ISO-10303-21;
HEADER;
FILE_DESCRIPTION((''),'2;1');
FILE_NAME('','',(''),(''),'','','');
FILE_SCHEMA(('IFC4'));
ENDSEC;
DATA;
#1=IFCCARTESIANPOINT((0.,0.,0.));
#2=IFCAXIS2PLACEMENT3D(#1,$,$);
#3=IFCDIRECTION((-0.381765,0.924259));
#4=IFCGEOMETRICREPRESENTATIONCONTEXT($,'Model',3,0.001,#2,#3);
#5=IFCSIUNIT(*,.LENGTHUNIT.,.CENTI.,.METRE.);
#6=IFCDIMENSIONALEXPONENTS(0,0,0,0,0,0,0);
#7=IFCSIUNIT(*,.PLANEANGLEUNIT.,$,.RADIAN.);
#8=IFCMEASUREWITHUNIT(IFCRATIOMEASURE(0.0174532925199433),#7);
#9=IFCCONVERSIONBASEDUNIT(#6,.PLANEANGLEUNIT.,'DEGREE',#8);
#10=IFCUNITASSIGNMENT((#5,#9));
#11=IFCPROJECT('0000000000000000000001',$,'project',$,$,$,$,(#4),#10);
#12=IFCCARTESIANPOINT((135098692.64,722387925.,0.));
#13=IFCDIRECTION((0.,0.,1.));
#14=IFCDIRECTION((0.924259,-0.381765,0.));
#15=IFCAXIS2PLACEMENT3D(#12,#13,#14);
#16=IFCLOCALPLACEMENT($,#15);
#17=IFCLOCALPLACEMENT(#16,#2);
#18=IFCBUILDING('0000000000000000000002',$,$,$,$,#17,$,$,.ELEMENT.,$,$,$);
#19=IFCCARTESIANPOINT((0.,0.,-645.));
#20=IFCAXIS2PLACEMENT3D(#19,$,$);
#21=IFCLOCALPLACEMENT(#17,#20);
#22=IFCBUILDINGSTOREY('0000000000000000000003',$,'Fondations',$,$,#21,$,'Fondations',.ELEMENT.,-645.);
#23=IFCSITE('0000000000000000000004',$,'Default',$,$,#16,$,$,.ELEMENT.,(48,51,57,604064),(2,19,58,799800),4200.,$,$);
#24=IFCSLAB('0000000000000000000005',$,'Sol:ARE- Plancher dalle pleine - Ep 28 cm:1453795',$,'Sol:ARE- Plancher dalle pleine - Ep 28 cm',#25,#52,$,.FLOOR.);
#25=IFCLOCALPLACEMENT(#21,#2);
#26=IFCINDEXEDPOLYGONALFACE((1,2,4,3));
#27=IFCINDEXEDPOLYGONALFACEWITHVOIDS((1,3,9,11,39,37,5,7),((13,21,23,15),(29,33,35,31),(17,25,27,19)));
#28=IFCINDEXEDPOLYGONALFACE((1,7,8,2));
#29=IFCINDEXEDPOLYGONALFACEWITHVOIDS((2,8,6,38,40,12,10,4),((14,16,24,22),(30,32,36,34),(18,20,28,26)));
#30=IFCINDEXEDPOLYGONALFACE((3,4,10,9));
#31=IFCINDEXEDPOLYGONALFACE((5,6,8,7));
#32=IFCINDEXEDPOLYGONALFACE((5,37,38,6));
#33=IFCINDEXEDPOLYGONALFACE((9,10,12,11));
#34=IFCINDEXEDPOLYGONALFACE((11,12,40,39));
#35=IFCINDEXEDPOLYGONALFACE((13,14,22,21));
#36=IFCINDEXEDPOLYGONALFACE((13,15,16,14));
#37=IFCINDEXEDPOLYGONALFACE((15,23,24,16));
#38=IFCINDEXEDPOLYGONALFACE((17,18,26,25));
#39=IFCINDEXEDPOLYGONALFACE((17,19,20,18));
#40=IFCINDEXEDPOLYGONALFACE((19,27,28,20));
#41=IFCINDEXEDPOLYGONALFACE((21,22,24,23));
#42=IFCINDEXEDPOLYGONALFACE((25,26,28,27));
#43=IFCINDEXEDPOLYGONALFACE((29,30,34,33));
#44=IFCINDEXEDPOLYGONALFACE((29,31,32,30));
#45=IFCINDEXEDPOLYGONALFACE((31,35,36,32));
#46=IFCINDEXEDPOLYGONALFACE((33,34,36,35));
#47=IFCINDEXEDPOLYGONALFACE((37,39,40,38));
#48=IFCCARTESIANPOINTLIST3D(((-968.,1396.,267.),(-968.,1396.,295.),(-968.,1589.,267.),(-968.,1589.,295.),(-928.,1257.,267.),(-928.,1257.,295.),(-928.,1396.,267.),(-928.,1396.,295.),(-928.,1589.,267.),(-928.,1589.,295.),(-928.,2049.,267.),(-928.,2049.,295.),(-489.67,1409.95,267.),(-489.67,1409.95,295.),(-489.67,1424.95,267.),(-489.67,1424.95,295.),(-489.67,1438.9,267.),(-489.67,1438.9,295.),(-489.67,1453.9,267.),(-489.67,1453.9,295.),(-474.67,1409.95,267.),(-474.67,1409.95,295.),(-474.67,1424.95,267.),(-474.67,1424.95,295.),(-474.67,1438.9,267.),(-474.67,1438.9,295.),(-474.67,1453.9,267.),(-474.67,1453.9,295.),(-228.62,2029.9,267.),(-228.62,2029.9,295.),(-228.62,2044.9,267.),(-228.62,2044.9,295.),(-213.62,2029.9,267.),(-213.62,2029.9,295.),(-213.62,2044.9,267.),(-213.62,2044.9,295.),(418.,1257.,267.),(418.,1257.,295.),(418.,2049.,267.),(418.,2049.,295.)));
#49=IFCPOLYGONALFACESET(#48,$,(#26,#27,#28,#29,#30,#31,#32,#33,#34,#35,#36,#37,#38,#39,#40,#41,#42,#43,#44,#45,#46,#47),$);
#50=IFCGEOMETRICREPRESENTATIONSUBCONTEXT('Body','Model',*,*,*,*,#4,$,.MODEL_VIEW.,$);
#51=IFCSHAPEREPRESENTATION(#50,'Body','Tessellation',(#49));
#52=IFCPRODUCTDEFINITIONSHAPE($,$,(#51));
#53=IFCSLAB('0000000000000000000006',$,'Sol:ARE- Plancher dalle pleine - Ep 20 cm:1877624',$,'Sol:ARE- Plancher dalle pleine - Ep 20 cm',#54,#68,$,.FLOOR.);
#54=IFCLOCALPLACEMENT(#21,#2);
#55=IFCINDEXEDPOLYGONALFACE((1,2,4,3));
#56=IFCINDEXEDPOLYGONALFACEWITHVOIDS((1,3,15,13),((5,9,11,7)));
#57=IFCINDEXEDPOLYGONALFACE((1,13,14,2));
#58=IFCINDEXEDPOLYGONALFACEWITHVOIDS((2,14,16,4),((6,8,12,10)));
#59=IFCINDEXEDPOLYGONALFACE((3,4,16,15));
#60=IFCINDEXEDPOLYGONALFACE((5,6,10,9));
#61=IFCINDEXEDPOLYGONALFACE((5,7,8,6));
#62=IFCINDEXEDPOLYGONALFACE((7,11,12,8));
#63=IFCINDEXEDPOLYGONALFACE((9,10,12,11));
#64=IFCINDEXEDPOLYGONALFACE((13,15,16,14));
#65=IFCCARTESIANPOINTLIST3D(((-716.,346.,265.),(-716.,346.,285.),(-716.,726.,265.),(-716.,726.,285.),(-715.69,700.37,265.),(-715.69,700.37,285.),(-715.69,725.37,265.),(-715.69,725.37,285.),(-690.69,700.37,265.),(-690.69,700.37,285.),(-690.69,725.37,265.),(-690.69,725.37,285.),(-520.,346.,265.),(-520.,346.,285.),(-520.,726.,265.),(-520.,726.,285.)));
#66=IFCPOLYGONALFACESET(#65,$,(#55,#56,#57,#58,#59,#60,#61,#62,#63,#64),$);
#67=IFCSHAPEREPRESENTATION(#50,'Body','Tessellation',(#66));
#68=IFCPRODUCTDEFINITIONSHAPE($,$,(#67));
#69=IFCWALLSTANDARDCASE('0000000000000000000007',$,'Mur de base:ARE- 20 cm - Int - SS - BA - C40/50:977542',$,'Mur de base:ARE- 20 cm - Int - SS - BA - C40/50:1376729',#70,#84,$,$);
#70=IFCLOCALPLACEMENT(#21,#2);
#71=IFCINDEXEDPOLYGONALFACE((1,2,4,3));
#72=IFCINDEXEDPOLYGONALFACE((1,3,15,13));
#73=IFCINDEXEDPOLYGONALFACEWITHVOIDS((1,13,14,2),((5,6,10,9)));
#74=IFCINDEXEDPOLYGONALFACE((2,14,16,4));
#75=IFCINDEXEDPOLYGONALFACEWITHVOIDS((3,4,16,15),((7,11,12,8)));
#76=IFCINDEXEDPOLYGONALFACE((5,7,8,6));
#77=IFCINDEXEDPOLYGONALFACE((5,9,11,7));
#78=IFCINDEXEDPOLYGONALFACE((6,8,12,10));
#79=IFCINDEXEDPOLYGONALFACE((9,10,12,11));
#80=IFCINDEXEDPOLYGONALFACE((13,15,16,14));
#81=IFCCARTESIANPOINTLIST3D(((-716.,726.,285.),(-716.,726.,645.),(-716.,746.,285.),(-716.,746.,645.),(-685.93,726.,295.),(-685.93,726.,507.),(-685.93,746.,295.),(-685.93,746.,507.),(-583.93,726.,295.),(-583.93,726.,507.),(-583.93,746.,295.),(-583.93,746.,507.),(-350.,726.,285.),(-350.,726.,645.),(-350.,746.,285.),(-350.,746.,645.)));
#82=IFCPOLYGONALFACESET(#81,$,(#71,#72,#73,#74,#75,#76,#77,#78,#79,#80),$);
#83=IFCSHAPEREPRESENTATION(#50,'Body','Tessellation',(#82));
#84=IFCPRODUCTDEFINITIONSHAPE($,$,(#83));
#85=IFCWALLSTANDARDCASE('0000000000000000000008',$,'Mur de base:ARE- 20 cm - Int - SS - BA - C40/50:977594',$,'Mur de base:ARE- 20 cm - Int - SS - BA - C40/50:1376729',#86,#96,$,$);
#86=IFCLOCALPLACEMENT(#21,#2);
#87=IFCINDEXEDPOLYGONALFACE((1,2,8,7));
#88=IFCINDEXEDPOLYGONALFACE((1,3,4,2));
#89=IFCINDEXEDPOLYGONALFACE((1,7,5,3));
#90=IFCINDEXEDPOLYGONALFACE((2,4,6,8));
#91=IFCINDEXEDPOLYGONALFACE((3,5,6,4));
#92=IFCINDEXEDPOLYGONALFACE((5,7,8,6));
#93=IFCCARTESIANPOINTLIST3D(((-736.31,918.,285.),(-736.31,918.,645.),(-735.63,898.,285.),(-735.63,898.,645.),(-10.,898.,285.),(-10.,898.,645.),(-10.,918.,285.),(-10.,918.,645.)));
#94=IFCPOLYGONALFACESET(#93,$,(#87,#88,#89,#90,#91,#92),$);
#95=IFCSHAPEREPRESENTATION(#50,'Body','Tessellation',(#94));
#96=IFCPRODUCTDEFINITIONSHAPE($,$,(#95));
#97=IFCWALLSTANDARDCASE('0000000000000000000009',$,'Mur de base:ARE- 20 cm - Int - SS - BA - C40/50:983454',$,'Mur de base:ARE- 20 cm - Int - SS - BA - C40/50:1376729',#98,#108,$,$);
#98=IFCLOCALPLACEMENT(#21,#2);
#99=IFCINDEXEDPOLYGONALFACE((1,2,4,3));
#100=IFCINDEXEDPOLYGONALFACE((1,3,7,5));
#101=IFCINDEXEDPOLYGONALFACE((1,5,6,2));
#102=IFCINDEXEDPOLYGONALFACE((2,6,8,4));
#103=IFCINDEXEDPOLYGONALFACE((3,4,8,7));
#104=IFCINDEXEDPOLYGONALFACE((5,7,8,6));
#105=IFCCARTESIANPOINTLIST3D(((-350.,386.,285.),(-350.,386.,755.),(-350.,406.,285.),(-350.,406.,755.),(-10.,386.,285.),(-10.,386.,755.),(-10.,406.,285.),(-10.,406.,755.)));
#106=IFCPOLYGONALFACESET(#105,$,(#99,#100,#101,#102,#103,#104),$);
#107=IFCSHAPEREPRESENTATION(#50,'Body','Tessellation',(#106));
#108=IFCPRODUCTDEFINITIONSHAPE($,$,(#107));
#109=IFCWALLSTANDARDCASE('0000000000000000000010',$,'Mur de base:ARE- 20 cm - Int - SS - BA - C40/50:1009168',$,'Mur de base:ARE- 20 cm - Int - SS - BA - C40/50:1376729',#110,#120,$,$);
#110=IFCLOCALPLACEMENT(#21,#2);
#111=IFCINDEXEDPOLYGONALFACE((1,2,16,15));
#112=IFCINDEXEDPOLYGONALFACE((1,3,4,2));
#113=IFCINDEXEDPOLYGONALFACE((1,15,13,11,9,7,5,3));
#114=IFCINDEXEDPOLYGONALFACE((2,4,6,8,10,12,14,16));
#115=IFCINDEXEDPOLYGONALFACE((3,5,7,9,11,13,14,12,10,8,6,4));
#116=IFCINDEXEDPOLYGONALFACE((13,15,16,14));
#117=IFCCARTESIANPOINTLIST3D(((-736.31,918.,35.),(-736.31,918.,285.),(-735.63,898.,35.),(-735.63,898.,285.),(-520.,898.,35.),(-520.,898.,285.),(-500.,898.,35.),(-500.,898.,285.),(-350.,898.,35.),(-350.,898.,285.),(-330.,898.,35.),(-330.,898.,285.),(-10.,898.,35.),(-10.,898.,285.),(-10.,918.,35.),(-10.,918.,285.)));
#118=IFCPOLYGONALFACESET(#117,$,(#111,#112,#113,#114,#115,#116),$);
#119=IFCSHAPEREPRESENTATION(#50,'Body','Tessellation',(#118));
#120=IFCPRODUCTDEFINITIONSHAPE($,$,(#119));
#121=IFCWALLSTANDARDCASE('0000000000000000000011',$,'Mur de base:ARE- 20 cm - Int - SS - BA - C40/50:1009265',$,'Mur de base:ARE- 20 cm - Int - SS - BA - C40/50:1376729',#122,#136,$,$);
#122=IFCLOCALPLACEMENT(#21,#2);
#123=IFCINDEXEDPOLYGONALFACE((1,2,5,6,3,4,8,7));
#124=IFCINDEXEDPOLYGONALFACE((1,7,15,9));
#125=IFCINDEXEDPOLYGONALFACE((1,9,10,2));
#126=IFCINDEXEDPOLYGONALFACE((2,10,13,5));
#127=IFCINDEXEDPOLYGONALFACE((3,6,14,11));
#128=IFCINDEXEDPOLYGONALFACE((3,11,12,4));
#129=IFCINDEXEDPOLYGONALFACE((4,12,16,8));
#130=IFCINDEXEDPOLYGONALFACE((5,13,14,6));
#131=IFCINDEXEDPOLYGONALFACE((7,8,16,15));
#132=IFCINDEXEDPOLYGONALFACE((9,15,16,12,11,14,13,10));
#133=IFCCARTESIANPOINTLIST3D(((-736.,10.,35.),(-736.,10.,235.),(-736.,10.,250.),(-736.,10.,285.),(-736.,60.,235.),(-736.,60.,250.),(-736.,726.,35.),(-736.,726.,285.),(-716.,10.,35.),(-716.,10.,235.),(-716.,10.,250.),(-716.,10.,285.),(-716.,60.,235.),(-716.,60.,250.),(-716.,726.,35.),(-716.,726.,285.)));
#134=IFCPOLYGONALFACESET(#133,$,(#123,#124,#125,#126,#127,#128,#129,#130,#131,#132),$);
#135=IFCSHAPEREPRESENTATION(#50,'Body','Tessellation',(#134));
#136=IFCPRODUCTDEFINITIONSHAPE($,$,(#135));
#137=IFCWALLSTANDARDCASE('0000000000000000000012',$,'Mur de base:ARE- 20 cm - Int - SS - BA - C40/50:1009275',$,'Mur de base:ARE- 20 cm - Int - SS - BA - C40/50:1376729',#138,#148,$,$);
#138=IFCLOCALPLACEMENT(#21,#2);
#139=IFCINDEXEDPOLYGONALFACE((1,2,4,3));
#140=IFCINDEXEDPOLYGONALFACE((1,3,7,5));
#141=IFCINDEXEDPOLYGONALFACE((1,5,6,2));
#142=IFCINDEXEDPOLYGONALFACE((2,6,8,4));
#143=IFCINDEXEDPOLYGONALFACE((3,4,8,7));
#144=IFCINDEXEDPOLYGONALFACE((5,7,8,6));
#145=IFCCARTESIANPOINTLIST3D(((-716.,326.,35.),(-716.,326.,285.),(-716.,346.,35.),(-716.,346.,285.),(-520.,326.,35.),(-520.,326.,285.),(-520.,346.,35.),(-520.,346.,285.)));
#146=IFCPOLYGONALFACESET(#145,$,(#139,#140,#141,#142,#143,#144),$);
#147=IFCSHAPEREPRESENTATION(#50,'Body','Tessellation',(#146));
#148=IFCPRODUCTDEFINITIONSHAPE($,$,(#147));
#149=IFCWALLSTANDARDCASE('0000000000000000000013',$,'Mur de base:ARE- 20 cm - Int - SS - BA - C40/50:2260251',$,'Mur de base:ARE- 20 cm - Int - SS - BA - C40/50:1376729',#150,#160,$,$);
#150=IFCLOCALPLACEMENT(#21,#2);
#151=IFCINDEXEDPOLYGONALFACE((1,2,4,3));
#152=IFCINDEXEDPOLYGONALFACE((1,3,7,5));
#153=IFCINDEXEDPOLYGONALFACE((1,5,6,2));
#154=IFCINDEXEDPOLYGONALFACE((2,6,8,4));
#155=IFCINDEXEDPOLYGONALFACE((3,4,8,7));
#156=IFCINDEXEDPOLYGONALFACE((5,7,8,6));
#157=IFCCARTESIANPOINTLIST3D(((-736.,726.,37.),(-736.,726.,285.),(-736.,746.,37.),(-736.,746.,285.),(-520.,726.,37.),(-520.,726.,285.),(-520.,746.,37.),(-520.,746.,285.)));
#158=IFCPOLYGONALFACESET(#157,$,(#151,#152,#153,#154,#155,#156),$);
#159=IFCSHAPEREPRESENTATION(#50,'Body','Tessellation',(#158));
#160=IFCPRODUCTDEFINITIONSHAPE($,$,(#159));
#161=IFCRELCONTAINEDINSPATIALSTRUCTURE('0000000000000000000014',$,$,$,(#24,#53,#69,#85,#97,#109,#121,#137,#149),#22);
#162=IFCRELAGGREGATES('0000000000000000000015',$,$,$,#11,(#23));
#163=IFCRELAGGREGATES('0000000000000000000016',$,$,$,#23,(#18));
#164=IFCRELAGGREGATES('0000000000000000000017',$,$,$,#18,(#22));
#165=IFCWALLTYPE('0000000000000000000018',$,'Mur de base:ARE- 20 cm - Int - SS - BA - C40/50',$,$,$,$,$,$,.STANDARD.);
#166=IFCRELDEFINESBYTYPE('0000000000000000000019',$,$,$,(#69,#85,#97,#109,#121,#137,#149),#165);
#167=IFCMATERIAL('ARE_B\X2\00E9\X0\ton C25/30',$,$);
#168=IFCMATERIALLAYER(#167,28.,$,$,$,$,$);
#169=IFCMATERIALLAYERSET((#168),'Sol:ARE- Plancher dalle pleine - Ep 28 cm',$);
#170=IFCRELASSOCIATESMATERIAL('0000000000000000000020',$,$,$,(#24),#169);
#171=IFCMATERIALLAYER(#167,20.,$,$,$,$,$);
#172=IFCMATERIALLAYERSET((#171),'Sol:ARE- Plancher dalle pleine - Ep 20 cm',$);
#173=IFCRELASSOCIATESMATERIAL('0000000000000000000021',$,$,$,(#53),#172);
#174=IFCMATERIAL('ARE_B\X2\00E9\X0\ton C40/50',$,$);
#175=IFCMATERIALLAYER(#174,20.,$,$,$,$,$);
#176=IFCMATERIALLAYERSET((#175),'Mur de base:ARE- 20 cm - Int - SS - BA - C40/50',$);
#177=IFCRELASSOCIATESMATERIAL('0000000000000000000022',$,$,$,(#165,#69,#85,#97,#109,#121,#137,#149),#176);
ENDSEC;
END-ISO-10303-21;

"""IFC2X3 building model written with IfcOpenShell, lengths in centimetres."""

from ifc_helpers import new_model, entity, si_unit, converted_unit, direction, frame, frame_2d, origin, origin_2d_with_axis, place, context, subcontext, project, spatial, polyline, rectangle, outline, extrude, material, layer, layer_set, layer_usage, type_object, element, save


model = new_model("IFC2X3")

# Units and contexts
model_context = context("Model", 3, precision=0.001, world=origin(), true_north=direction((-0.381765, 0.924259)))
body_context = subcontext(model_context, "Body", "Model", "MODEL_VIEW")
ifc_project = project(units=[si_unit("LENGTHUNIT", "METRE", prefix="CENTI"), converted_unit("PLANEANGLEUNIT", "DEGREE", entity("IfcRatioMeasure", 0.0174532925199433), si_unit("PLANEANGLEUNIT", "RADIAN"), dimensions=[0, 0, 0, 0, 0, 0, 0])], contexts=[model_context])

# Site, building, storey
site_placement = place(None, frame((135098692.64, 722387925.0, 0.0), z_axis=(0.0, 0.0, 1.0), x_axis=(0.924259, -0.381765, 0.0)))
site = spatial("IfcSite", under=ifc_project, at=site_placement, Name="Default", CompositionType="ELEMENT", RefLatitude=(48, 51, 57, 604064), RefLongitude=(2, 19, 58, 799800), RefElevation=4200.0)
building_placement = place(site_placement, origin())
building = spatial("IfcBuilding", under=site, at=building_placement, CompositionType="ELEMENT")
storey_placement = place(building_placement, frame((0.0, 0.0, -645.0)))
storey = spatial("IfcBuildingStorey", under=building, at=storey_placement, Name="Fondations", LongName="Fondations", CompositionType="ELEMENT", Elevation=-645.0)

# Shared definitions
ifc_material_1 = material(Name="ARE_Béton C25/30")

# Slab, openings
ifc_layer_1 = layer(ifc_material_1, 28.0)
ifc_layer_set_1 = layer_set([ifc_layer_1], Name="Sol:ARE- Plancher dalle pleine - Ep 28 cm")
ifc_layer_usage_1 = layer_usage(ifc_layer_set_1, "AXIS3", "POSITIVE", 0.0)
slab_1_placement = place(storey_placement, frame((-968.0, 1257.0, 267.0)))
slab_1 = element("IfcSlab", 1, at=slab_1_placement, inside=storey, material=ifc_layer_usage_1, Name="Sol:ARE- Plancher dalle pleine - Ep 28 cm:1453795", ObjectType="Sol:ARE- Plancher dalle pleine - Ep 28 cm", PredefinedType="FLOOR", context=body_context, shape_type="SweptSolid", body=[
    extrude(outline(polyline([(-693.0, 396.0), (-693.0, -396.0), (653.0, -396.0), (653.0, -257.0), (693.0, -257.0), (693.0, -64.0), (653.0, -64.0), (653.0, 396.0), (-693.0, 396.0)])), frame((693.0, 396.0, 28.0), z_axis=(0.0, 0.0, -1.0), x_axis=(-1.0, 0.0, 0.0)), (0.0, 0.0, 1.0), 28.0),
])
opening_1_placement = place(slab_1_placement, origin())
element("IfcOpeningElement", 2, at=opening_1_placement, cuts=slab_1, ObjectType="Opening", context=body_context, shape_type="SweptSolid", body=[
    extrude(rectangle(XDim=15.0, YDim=15.0, at=origin_2d_with_axis()), frame((485.83, 160.45, 0.0), z_axis=(0.0, 0.0, 1.0), x_axis=(0.0, -1.0, 0.0)), (0.0, 0.0, 1.0), 28.0),
])
opening_2_placement = place(slab_1_placement, origin())
element("IfcOpeningElement", 3, at=opening_2_placement, cuts=slab_1, ObjectType="Opening", context=body_context, shape_type="SweptSolid", body=[
    extrude(rectangle(XDim=15.0, YDim=15.0, at=origin_2d_with_axis()), frame((485.83, 189.4, 0.0), z_axis=(0.0, 0.0, 1.0), x_axis=(0.0, -1.0, 0.0)), (0.0, 0.0, 1.0), 28.0),
])
opening_3_placement = place(slab_1_placement, origin())
element("IfcOpeningElement", 4, at=opening_3_placement, cuts=slab_1, ObjectType="Opening", context=body_context, shape_type="SweptSolid", body=[
    extrude(rectangle(XDim=15.0, YDim=15.0, at=origin_2d_with_axis()), frame((746.88, 780.4, 0.0), z_axis=(0.0, 0.0, 1.0), x_axis=(0.0, -1.0, 0.0)), (0.0, 0.0, 1.0), 28.0),
])

# Slab, opening
ifc_layer_2 = layer(ifc_material_1, 20.0)
ifc_layer_set_2 = layer_set([ifc_layer_2], Name="Sol:ARE- Plancher dalle pleine - Ep 20 cm")
ifc_layer_usage_2 = layer_usage(ifc_layer_set_2, "AXIS3", "POSITIVE", 0.0)
slab_2_placement = place(storey_placement, frame((-716.0, 346.0, 265.0)))
slab_2 = element("IfcSlab", 5, at=slab_2_placement, inside=storey, material=ifc_layer_usage_2, Name="Sol:ARE- Plancher dalle pleine - Ep 20 cm:1877624", ObjectType="Sol:ARE- Plancher dalle pleine - Ep 20 cm", PredefinedType="FLOOR", context=body_context, shape_type="SweptSolid", body=[
    extrude(rectangle(XDim=380.0, YDim=196.0, at=frame_2d((0.0, 0.0), x_axis=(0.0, -1.0))), frame((98.0, 190.0, 20.0), z_axis=(0.0, 0.0, -1.0), x_axis=(-1.0, 0.0, 0.0)), (0.0, 0.0, 1.0), 20.0),
])
opening_4_placement = place(slab_2_placement, origin())
element("IfcOpeningElement", 6, at=opening_4_placement, cuts=slab_2, ObjectType="Opening", context=body_context, shape_type="SweptSolid", body=[
    extrude(rectangle(XDim=25.0, YDim=25.0, at=origin_2d_with_axis()), frame((12.81, 366.87, 0.0), z_axis=(0.0, 0.0, 1.0), x_axis=(-1.0, 0.0, 0.0)), (0.0, 0.0, 1.0), 20.0),
])

# Wall, openings
ifc_material_2 = material(Name="ARE_Béton C40/50")
ifc_layer_3 = layer(ifc_material_2, 20.0)
ifc_layer_set_3 = layer_set([ifc_layer_3], Name="Mur de base:ARE- 20 cm - Int - SS - BA - C40/50")
ifc_layer_usage_3 = layer_usage(ifc_layer_set_3, "AXIS2", "NEGATIVE", 10.0)
wall_type_1 = type_object("IfcWallType", Name="Mur de base:ARE- 20 cm - Int - SS - BA - C40/50", PredefinedType="STANDARD", material=ifc_layer_set_3)
wall_1_placement = place(storey_placement, frame((-716.0, 736.0, 285.0)))
wall_1 = element("IfcWallStandardCase", 7, at=wall_1_placement, inside=storey, type_object=wall_type_1, material=ifc_layer_usage_3, Name="Mur de base:ARE- 20 cm - Int - SS - BA - C40/50:977542", ObjectType="Mur de base:ARE- 20 cm - Int - SS - BA - C40/50:1376729", context=body_context, shape_type="SweptSolid", body=[
    extrude(rectangle(XDim=366.0, YDim=20.0, at=frame_2d((183.0, 0.0), x_axis=(-1.0, 0.0))), origin(), (0.0, 0.0, 1.0), 360.0),
])
opening_5_placement = place(wall_1_placement, origin())
element("IfcOpeningElement", 8, at=opening_5_placement, cuts=wall_1, ObjectType="Opening", context=body_context, shape_type="SweptSolid", body=[
    extrude(rectangle(XDim=212.0, YDim=15.0, at=frame_2d((0.0, 0.0), x_axis=(0.0, 1.0))), frame((322.5, -112.0, 106.0), z_axis=(0.0, 1.0, 0.0), x_axis=(-1.0, 0.0, 0.0)), (0.0, 0.0, 1.0), 102.0),
])
opening_6_placement = place(wall_1_placement, frame((716.0, -736.0, -285.0)))
element("IfcOpeningElement", 9, at=opening_6_placement, cuts=wall_1, ObjectType="Opening", context=body_context, shape_type="SweptSolid", body=[
    extrude(rectangle(XDim=212.0, YDim=102.0, at=origin_2d_with_axis()), frame((-634.93, 593.6, 401.0), z_axis=(0.0, 1.0, 0.0), x_axis=(0.0, 0.0, -1.0)), (0.0, 0.0, 1.0), 304.8),
])

# Walls
ifc_layer_usage_4 = layer_usage(ifc_layer_set_3, "AXIS2", "NEGATIVE", 10.0)
wall_2_placement = place(storey_placement, frame((-736.31, 908.0, 285.0)))
element("IfcWallStandardCase", 10, at=wall_2_placement, inside=storey, type_object=wall_type_1, material=ifc_layer_usage_4, Name="Mur de base:ARE- 20 cm - Int - SS - BA - C40/50:977594", ObjectType="Mur de base:ARE- 20 cm - Int - SS - BA - C40/50:1376729", context=body_context, shape_type="SweptSolid", body=[
    extrude(outline(polyline([(726.31, -10.0), (726.31, 10.0), (0.0, 10.0), (0.67, -10.0), (726.31, -10.0)])), origin(), (0.0, 0.0, 1.0), 360.0),
])
ifc_layer_usage_5 = layer_usage(ifc_layer_set_3, "AXIS2", "NEGATIVE", 10.0)
wall_3_placement = place(storey_placement, frame((-350.0, 396.0, 285.0)))
element("IfcWallStandardCase", 11, at=wall_3_placement, inside=storey, type_object=wall_type_1, material=ifc_layer_usage_5, Name="Mur de base:ARE- 20 cm - Int - SS - BA - C40/50:983454", ObjectType="Mur de base:ARE- 20 cm - Int - SS - BA - C40/50:1376729", context=body_context, shape_type="SweptSolid", body=[
    extrude(rectangle(XDim=340.0, YDim=20.0, at=frame_2d((170.0, 0.0), x_axis=(-1.0, 0.0))), origin(), (0.0, 0.0, 1.0), 470.0),
])
ifc_layer_usage_6 = layer_usage(ifc_layer_set_3, "AXIS2", "NEGATIVE", 10.0)
wall_4_placement = place(storey_placement, frame((-736.31, 908.0, 35.0)))
element("IfcWallStandardCase", 12, at=wall_4_placement, inside=storey, type_object=wall_type_1, material=ifc_layer_usage_6, Name="Mur de base:ARE- 20 cm - Int - SS - BA - C40/50:1009168", ObjectType="Mur de base:ARE- 20 cm - Int - SS - BA - C40/50:1376729", context=body_context, shape_type="SweptSolid", body=[
    extrude(outline(polyline([(726.31, -10.0), (726.31, 10.0), (0.0, 10.0), (0.67, -10.0), (216.31, -10.0), (236.31, -10.0), (386.31, -10.0), (406.31, -10.0), (726.31, -10.0)])), origin(), (0.0, 0.0, 1.0), 250.0),
])

# Wall, opening
ifc_layer_usage_7 = layer_usage(ifc_layer_set_3, "AXIS2", "NEGATIVE", 10.0)
wall_5_placement = place(storey_placement, frame((-726.0, 726.0, 35.0), z_axis=(0.0, 0.0, 1.0), x_axis=(0.0, -1.0, 0.0)))
wall_5 = element("IfcWallStandardCase", 13, at=wall_5_placement, inside=storey, type_object=wall_type_1, material=ifc_layer_usage_7, Name="Mur de base:ARE- 20 cm - Int - SS - BA - C40/50:1009265", ObjectType="Mur de base:ARE- 20 cm - Int - SS - BA - C40/50:1376729", context=body_context, shape_type="SweptSolid", body=[
    extrude(rectangle(XDim=716.0, YDim=20.0, at=frame_2d((358.0, 0.0), x_axis=(-1.0, 0.0))), origin(), (0.0, 0.0, 1.0), 250.0),
])
opening_7_placement = place(wall_5_placement, origin())
element("IfcOpeningElement", 14, at=opening_7_placement, cuts=wall_5, ObjectType="Opening", context=body_context, shape_type="SweptSolid", body=[
    extrude(rectangle(XDim=15.0, YDim=50.0, at=frame_2d((0.0, 0.0), x_axis=(0.0, 1.0))), frame((691.0, -10.0, 207.5), z_axis=(0.0, 1.0, 0.0), x_axis=(1.0, 0.0, 0.0)), (0.0, 0.0, 1.0), 20.0),
])

# Walls
ifc_layer_usage_8 = layer_usage(ifc_layer_set_3, "AXIS2", "NEGATIVE", 10.0)
wall_6_placement = place(storey_placement, frame((-716.0, 336.0, 35.0)))
element("IfcWallStandardCase", 15, at=wall_6_placement, inside=storey, type_object=wall_type_1, material=ifc_layer_usage_8, Name="Mur de base:ARE- 20 cm - Int - SS - BA - C40/50:1009275", ObjectType="Mur de base:ARE- 20 cm - Int - SS - BA - C40/50:1376729", context=body_context, shape_type="SweptSolid", body=[
    extrude(rectangle(XDim=196.0, YDim=20.0, at=frame_2d((98.0, 0.0), x_axis=(-1.0, 0.0))), origin(), (0.0, 0.0, 1.0), 250.0),
])
ifc_layer_usage_9 = layer_usage(ifc_layer_set_3, "AXIS2", "NEGATIVE", 10.0)
wall_7_placement = place(storey_placement, frame((-736.0, 736.0, 37.0)))
element("IfcWallStandardCase", 16, at=wall_7_placement, inside=storey, type_object=wall_type_1, material=ifc_layer_usage_9, Name="Mur de base:ARE- 20 cm - Int - SS - BA - C40/50:2260251", ObjectType="Mur de base:ARE- 20 cm - Int - SS - BA - C40/50:1376729", context=body_context, shape_type="SweptSolid", body=[
    extrude(rectangle(XDim=216.0, YDim=20.0, at=frame_2d((108.0, 0.0), x_axis=(-1.0, 0.0))), origin(), (0.0, 0.0, 1.0), 248.0),
])

save(model, "model.ifc")
